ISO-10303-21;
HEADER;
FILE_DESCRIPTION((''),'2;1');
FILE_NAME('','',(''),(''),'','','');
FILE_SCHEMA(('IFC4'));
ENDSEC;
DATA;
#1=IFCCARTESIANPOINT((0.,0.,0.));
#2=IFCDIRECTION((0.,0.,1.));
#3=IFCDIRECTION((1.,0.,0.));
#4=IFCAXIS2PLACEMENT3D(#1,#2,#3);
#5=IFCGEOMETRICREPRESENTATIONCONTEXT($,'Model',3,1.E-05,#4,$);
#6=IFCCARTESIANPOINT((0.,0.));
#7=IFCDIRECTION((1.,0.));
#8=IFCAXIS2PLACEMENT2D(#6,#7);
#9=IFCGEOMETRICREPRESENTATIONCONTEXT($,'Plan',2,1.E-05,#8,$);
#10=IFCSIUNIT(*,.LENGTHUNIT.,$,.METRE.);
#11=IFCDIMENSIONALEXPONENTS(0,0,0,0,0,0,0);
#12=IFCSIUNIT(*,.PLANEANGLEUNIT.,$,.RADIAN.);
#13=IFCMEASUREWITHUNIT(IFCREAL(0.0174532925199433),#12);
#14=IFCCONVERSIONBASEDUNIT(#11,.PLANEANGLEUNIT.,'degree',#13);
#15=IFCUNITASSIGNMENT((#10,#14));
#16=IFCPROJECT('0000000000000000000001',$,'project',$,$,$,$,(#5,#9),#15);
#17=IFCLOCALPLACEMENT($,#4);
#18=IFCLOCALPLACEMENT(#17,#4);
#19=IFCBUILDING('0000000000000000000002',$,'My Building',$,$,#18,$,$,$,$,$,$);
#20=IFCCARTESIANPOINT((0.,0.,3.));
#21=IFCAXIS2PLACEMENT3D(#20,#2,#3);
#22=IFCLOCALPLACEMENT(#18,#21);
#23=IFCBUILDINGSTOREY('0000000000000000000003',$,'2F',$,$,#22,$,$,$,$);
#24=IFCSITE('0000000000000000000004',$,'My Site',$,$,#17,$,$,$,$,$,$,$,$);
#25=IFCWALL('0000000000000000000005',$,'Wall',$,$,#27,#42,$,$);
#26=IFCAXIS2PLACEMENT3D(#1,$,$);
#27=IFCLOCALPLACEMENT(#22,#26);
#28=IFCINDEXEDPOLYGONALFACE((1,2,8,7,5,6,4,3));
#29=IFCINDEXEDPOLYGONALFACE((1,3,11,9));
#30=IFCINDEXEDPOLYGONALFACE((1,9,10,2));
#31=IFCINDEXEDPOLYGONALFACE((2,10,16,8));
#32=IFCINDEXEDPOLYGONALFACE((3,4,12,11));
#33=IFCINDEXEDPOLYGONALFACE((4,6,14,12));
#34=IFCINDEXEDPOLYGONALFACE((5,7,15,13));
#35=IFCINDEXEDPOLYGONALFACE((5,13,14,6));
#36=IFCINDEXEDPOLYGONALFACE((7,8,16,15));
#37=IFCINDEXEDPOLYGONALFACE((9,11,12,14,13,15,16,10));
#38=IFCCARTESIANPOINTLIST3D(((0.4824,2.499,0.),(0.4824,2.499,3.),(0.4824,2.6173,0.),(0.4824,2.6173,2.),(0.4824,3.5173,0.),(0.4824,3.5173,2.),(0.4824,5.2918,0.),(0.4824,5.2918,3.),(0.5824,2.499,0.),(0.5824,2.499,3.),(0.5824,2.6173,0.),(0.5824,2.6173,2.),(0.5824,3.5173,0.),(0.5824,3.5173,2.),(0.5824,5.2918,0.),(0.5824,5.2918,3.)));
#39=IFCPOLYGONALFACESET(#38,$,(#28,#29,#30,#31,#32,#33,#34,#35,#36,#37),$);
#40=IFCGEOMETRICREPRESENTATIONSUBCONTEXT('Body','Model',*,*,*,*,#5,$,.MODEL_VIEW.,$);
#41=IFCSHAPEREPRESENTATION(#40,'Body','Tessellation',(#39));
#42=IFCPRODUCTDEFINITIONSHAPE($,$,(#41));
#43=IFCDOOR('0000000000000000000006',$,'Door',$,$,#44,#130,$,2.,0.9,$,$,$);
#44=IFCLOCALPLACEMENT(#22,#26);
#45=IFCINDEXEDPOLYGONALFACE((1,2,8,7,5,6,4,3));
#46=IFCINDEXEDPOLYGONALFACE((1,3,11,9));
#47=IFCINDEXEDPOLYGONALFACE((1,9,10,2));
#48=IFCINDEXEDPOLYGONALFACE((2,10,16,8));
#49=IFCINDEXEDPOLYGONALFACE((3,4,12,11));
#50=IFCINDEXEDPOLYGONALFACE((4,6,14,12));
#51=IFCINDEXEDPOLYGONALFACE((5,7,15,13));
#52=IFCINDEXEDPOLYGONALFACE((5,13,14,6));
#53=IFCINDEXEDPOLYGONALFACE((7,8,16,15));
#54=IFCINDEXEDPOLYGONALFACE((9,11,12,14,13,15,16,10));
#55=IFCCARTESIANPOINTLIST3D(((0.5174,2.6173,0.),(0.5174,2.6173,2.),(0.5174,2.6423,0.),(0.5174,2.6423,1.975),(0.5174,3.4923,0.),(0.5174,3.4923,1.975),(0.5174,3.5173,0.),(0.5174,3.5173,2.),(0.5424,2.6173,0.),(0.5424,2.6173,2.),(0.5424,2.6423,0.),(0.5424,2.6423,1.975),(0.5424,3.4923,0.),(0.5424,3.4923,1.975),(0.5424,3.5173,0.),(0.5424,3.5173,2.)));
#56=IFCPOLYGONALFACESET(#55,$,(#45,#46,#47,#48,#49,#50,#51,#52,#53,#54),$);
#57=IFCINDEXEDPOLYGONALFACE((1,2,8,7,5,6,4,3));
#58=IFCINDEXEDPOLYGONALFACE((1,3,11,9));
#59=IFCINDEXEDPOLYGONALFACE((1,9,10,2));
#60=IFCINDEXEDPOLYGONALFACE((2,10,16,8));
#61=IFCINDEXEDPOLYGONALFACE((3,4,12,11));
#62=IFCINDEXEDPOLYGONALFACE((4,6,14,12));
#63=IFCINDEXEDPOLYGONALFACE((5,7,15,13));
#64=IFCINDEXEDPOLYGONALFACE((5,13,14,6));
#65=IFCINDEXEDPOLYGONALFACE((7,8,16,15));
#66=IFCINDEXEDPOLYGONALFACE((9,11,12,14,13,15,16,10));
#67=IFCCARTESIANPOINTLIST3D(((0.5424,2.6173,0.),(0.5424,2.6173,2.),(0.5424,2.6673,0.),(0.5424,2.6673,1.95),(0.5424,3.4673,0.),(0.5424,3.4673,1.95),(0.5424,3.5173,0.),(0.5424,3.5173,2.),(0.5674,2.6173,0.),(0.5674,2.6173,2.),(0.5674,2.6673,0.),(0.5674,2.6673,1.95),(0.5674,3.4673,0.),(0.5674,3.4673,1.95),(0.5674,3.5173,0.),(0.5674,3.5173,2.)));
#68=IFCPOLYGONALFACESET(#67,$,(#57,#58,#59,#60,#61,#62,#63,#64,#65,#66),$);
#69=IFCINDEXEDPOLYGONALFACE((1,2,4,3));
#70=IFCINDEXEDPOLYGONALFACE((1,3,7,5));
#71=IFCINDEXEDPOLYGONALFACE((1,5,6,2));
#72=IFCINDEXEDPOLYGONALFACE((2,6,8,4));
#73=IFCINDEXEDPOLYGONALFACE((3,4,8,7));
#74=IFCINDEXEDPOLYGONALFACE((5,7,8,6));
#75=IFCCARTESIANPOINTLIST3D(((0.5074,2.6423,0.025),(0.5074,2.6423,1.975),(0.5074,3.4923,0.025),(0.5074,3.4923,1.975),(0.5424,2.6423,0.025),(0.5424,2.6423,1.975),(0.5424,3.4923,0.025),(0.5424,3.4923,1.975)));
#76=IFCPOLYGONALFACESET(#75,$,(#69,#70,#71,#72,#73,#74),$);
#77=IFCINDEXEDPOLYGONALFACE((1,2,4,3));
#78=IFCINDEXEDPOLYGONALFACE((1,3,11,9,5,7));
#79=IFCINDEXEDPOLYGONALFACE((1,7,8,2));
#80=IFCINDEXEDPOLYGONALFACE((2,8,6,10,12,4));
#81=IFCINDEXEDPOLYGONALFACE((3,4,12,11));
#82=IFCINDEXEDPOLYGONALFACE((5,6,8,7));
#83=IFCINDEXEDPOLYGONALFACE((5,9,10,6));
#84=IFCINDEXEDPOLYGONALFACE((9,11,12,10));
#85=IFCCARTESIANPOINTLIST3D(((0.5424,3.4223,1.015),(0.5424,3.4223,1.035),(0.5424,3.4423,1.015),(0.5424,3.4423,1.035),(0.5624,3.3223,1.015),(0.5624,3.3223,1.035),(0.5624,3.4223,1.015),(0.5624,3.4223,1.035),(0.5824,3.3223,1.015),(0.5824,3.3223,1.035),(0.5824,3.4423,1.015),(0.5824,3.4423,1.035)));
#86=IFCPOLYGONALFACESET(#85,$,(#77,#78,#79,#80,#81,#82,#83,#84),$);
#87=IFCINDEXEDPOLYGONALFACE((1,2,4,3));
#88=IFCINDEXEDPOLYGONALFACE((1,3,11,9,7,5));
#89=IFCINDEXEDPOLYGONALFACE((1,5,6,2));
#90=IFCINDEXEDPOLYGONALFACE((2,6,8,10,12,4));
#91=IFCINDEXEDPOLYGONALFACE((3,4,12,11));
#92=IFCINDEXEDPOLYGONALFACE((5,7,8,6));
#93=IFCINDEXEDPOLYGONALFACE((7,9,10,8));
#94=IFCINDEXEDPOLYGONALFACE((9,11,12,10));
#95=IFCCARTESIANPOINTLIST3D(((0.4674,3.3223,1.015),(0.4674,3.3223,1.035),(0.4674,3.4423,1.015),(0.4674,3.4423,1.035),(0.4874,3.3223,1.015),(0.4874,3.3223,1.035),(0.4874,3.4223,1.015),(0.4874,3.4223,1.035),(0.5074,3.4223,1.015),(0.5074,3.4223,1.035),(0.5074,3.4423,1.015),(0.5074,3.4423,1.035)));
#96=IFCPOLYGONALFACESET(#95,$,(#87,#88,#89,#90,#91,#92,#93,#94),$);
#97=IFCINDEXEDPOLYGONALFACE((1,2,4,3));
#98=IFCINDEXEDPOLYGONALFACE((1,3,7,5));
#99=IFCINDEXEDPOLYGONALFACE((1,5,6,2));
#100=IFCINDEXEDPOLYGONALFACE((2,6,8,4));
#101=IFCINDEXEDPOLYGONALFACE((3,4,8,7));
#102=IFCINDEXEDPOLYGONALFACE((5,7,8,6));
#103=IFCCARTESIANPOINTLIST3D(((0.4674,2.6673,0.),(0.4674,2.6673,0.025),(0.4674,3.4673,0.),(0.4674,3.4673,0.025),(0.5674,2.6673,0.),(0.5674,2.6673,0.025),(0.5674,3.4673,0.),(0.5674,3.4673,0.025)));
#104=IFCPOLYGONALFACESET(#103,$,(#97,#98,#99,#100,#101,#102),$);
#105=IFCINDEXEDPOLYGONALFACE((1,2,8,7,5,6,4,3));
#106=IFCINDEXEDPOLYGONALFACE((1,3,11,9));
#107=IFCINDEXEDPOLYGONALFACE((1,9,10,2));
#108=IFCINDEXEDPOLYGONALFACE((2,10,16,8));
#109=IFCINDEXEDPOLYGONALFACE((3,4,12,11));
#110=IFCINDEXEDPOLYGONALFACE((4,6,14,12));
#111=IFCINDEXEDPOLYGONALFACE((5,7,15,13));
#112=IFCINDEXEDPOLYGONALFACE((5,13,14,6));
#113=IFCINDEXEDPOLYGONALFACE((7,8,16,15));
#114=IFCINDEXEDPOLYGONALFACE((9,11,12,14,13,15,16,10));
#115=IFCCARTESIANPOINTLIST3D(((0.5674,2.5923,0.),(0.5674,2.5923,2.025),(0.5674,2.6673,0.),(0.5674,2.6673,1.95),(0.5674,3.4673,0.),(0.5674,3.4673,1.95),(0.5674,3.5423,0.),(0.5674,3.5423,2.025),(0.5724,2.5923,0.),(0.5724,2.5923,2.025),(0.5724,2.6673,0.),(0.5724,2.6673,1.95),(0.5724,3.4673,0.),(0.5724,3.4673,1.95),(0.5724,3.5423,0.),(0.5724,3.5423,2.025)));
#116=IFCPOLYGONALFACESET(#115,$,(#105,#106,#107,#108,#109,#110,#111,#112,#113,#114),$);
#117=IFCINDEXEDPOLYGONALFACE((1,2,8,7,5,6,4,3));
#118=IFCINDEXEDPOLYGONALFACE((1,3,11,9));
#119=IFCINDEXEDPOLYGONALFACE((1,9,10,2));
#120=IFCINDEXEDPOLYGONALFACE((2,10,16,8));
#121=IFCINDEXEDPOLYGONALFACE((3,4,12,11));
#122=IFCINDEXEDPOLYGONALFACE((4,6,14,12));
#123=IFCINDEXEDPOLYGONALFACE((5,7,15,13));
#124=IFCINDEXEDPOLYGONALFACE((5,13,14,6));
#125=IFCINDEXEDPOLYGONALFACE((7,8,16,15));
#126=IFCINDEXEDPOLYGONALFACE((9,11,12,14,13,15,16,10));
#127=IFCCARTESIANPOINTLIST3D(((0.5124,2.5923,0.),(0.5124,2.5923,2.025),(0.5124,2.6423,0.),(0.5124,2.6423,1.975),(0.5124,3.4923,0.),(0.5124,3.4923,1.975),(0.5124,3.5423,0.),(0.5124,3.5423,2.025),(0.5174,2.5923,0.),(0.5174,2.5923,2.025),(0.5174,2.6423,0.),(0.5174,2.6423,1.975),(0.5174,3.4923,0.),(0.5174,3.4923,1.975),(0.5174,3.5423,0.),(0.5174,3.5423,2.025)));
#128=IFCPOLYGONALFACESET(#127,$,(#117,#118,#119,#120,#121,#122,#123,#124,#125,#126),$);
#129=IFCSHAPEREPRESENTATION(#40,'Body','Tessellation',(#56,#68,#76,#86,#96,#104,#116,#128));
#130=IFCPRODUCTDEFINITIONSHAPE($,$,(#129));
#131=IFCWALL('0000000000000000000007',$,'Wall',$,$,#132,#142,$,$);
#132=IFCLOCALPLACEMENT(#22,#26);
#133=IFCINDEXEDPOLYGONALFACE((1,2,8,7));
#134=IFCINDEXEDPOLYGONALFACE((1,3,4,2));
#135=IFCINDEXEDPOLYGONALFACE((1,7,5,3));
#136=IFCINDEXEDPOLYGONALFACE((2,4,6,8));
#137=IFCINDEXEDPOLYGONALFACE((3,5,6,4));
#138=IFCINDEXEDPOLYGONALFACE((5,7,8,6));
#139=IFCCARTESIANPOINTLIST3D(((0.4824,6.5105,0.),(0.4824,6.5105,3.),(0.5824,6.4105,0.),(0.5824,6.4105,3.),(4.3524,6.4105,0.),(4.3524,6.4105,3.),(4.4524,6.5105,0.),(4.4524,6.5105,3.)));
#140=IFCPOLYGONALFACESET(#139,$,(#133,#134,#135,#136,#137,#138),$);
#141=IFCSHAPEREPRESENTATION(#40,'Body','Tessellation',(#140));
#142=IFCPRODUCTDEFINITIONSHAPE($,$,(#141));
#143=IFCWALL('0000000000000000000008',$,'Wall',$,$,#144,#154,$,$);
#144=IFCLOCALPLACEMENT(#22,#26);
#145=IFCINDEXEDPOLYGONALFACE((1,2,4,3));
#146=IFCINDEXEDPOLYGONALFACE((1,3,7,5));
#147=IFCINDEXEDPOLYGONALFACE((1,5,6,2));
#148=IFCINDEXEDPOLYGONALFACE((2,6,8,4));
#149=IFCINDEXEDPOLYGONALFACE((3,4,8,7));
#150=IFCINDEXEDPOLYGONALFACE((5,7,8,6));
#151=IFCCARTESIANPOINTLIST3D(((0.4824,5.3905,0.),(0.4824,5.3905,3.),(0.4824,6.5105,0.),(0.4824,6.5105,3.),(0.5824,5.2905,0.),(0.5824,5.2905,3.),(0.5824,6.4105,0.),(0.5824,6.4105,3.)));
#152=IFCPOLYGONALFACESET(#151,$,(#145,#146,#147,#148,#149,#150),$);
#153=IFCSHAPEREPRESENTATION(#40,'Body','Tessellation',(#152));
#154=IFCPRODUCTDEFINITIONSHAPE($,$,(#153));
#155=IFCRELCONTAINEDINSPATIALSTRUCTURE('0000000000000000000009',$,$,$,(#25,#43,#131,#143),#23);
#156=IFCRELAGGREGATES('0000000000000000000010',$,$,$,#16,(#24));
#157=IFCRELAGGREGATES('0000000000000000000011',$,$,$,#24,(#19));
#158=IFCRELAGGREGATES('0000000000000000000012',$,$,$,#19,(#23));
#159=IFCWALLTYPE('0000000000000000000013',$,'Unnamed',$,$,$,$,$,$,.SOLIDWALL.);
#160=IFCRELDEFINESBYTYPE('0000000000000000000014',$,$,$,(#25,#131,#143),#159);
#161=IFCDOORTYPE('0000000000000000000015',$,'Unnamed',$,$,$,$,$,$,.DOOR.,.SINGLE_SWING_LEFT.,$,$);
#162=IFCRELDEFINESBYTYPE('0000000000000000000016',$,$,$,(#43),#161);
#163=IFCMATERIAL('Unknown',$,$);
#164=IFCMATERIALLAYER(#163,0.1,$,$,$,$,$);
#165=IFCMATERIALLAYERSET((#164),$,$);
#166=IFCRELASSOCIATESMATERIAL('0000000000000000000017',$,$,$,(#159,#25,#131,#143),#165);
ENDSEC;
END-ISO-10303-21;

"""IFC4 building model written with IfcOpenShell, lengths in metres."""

from ifc_helpers import new_model, entity, si_unit, converted_unit, frame, origin_with_axes, origin_2d_with_axis, place, context, subcontext, project, spatial, line, indexed_curve, outline, extrude, shape, source, transform, mapped, material, layer, layer_set, layer_usage, type_object, type_shapes, element, fill, save


model = new_model("IFC4")

# Units and contexts
model_context = context("Model", 3, precision=1e-05, world=origin_with_axes())
plan_context = context("Plan", 2, precision=1e-05, world=origin_2d_with_axis())
body_context_1 = subcontext(model_context, "Body", "Model", "MODEL_VIEW")
body_context_2 = subcontext(plan_context, "Body", "Plan", "PLAN_VIEW")
ifc_project = project(units=[si_unit("LENGTHUNIT", "METRE"), converted_unit("PLANEANGLEUNIT", "degree", entity("IfcReal", 0.0174532925199433), si_unit("PLANEANGLEUNIT", "RADIAN"), dimensions=[0, 0, 0, 0, 0, 0, 0])], contexts=[model_context, plan_context])

# Site, building, storey
site_placement = place(None, origin_with_axes())
site = spatial("IfcSite", under=ifc_project, at=site_placement, Name="My Site")
building_placement = place(site_placement, origin_with_axes())
building = spatial("IfcBuilding", under=site, at=building_placement, Name="My Building")
storey_placement = place(building_placement, frame((0.0, 0.0, 3.0), z_axis=(0.0, 0.0, 1.0), x_axis=(1.0, 0.0, 0.0)))
storey = spatial("IfcBuildingStorey", under=building, at=storey_placement, Name="2F")

# Shared definitions
ifc_material = material(Name="Unknown")

# Shared definitions
ifc_layer = layer(ifc_material, 0.1)
ifc_layer_set = layer_set([ifc_layer])
wall_type = type_object("IfcWallType", Name="Unnamed", PredefinedType="SOLIDWALL", material=ifc_layer_set)

# Wall, opening, door
shared_shape_1 = source(origin_with_axes(), body_context_1, "Body", "SweptSolid", [
    extrude(outline(indexed_curve([(0.0, 0.0), (0.9, 0.0), (0.9, 2.0), (0.0, 2.0)], segments=[line(1, 2, 3, 4, 1)])), frame((0.0, -0.6, 0.0), z_axis=(0.0, -1.0, 0.0), x_axis=(1.0, 0.0, 0.0)), (0.0, 0.0, -1.0), 1.2),
])
door_type_1 = type_object("IfcDoorType", Name="Unnamed", OperationType="SINGLE_SWING_LEFT", PredefinedType="DOOR")
shared_shape_2 = source(origin_with_axes(), body_context_1, "Body", "SweptSolid", [
    extrude(outline(indexed_curve([(0.0, 0.0), (0.0, 2.0), (0.9, 2.0), (0.9, 0.0), (0.875, 0.0), (0.875, 1.975), (0.025, 1.975), (0.025, 0.0)], segments=[line(1, 2, 3, 4, 5, 6, 7, 8, 1)])), frame((0.0, 0.025, 0.0), z_axis=(0.0, -1.0, 0.0), x_axis=(1.0, 0.0, 0.0)), (0.0, 0.0, -1.0), 0.025),
    extrude(outline(indexed_curve([(0.0, 0.0), (0.0, 2.0), (0.9, 2.0), (0.9, 0.0), (0.85, 0.0), (0.85, 1.95), (0.05, 1.95), (0.05, 0.0)], segments=[line(1, 2, 3, 4, 5, 6, 7, 8, 1)])), frame((0.0, 0.0, 0.0), z_axis=(0.0, -1.0, 0.0), x_axis=(1.0, 0.0, 0.0)), (0.0, 0.0, -1.0), 0.025),
    extrude(outline(indexed_curve([(0.0, 0.0), (0.85, 0.0), (0.85, 0.035), (0.0, 0.035)], segments=[line(1, 2, 3, 4, 1)])), frame((0.025, 0.025, 0.025), z_axis=(0.0, 0.0, 1.0), x_axis=(1.0, 0.0, 0.0)), (0.0, 0.0, 1.0), 1.95),
    extrude(outline(indexed_curve([(0.0, 0.0), (0.0, -0.04), (-0.12, -0.04), (-0.12, -0.02), (-0.02, -0.02), (-0.02, 0.0)], segments=[line(1, 2, 3, 4, 5, 6, 1)])), frame((0.825, 0.025, 1.015), z_axis=(0.0, 0.0, 1.0), x_axis=(1.0, 0.0, 0.0)), (0.0, 0.0, 1.0), 0.02),
    extrude(outline(indexed_curve([(0.0, 0.0), (0.0, 0.04), (-0.12, 0.04), (-0.12, 0.02), (-0.02, 0.02), (-0.02, 0.0)], segments=[line(1, 2, 3, 4, 5, 6, 1)])), frame((0.825, 0.06, 1.015), z_axis=(0.0, 0.0, 1.0), x_axis=(1.0, 0.0, 0.0)), (0.0, 0.0, 1.0), 0.02),
    extrude(outline(indexed_curve([(0.0, 0.0), (0.8, 0.0), (0.8, 0.1), (0.0, 0.1)], segments=[line(1, 2, 3, 4, 1)])), frame((0.05, 0.0, 0.0), z_axis=(0.0, 0.0, 1.0), x_axis=(1.0, 0.0, 0.0)), (0.0, 0.0, 1.0), 0.025),
    extrude(outline(indexed_curve([(0.0, 0.0), (0.0, 2.025), (0.95, 2.025), (0.95, 0.0), (0.875, 0.0), (0.875, 1.95), (0.075, 1.95), (0.075, 0.0)], segments=[line(1, 2, 3, 4, 5, 6, 7, 8, 1)])), frame((-0.025, -0.005, 0.0), z_axis=(0.0, -1.0, 0.0), x_axis=(1.0, 0.0, 0.0)), (0.0, 0.0, -1.0), 0.005),
    extrude(outline(indexed_curve([(0.0, 0.0), (0.0, 2.025), (0.95, 2.025), (0.95, 0.0), (0.9, 0.0), (0.9, 1.975), (0.05, 1.975), (0.05, 0.0)], segments=[line(1, 2, 3, 4, 5, 6, 7, 8, 1)])), frame((-0.025, 0.05, 0.0), z_axis=(0.0, -1.0, 0.0), x_axis=(1.0, 0.0, 0.0)), (0.0, 0.0, -1.0), 0.005),
])
shared_shape_3 = source(origin_with_axes(), body_context_2, "Body", "Curve2D", [
    entity("IfcIndexedPolyCurve", entity("IfcCartesianPointList2D", [[0.0, 0.0], [0.0, 0.05], [0.025, 0.05], [0.025, 0.025], [0.05, 0.025], [0.05, 0.0]]), [entity("IfcLineIndex", [1, 2, 3, 4, 5, 6, 1])]),
    entity("IfcIndexedPolyCurve", entity("IfcCartesianPointList2D", [[0.9, 0.0], [0.9, 0.05], [0.875, 0.05], [0.875, 0.025], [0.85, 0.025], [0.85, 0.0]]), [entity("IfcLineIndex", [1, 2, 3, 4, 5, 6, 1])]),
    entity("IfcTrimmedCurve", entity("IfcEllipse", entity("IfcAxis2Placement2D", entity("IfcCartesianPoint", [0.06, 0.05]), entity("IfcDirection", [1.0, 0.0])), 0.815, 0.85), [entity("IfcCartesianPoint", [0.875, 0.05])], [entity("IfcCartesianPoint", [0.06, 0.9])], True, "CARTESIAN"),
    entity("IfcIndexedPolyCurve", entity("IfcCartesianPointList2D", [[0.025, 0.05], [0.06, 0.05], [0.06, 0.9], [0.025, 0.9]]), [entity("IfcLineIndex", [1, 2, 3, 4, 1])]),
])
type_shapes(door_type_1, [shared_shape_2, shared_shape_3])
ifc_layer_usage_1 = layer_usage(ifc_layer_set, "AXIS2", "POSITIVE", 0.0)
wall_1_placement = place(storey_placement, frame((0.4824, 5.2918, 0.0), z_axis=(0.0, 0.0, 1.0), x_axis=(0.0, -1.0, 0.0)))
wall_1 = element("IfcWall", 1, at=wall_1_placement, inside=storey, type_object=wall_type, material=ifc_layer_usage_1, Name="Wall", context=body_context_1, shape_type="SweptSolid", body=[
    extrude(outline(indexed_curve([(0.0, 0.0), (0.0, 0.1), (2.7929, 0.1), (2.7929, 0.0)], segments=[line(1, 2, 3, 4, 1)])), origin_with_axes(), (0.0, 0.0, 1.0), 3.0),
])
opening_1_placement = place(wall_1_placement, frame((1.7746, 0.0, 0.0), z_axis=(0.0, 0.0, 1.0), x_axis=(1.0, 0.0, 0.0)))
opening_1 = element("IfcOpeningElement", 2, at=opening_1_placement, cuts=wall_1, PredefinedType="OPENING", context=body_context_1, shape_type="MappedRepresentation", body=[
    mapped(shared_shape_1, transform((0.0, 0.0, 0.0), x_axis=(1.0, 0.0, 0.0), y_axis=(0.0, 1.0, 0.0), z_axis=(0.0, 0.0, 1.0), scale=1.0)),
])
door_1_placement = place(opening_1_placement, frame((0.9, 0.085, 0.0), z_axis=(0.0, 0.0, 1.0), x_axis=(-1.0, 0.0, 0.0)))
door_1 = element("IfcDoor", 3, at=door_1_placement, inside=storey, type_object=door_type_1, Name="Door", OverallHeight=2.0, OverallWidth=0.9, shapes=[
    shape(body_context_1, "Body", "MappedRepresentation", [mapped(shared_shape_2, transform((0.0, 0.0, 0.0), x_axis=(1.0, 0.0, 0.0), y_axis=(0.0, 1.0, 0.0), z_axis=(0.0, 0.0, 1.0), scale=1.0))]),
    shape(body_context_2, "Body", "MappedRepresentation", [mapped(shared_shape_3, transform((0.0, 0.0, 0.0), x_axis=(1.0, 0.0, 0.0), y_axis=(0.0, 1.0, 0.0), z_axis=(0.0, 0.0, 1.0), scale=1.0))]),
])
fill(opening_1, door_1)

# Walls
ifc_layer_usage_2 = layer_usage(ifc_layer_set, "AXIS2", "POSITIVE", 0.0)
wall_2_placement = place(storey_placement, frame((4.4524, 6.5105, 0.0), z_axis=(0.0, 0.0, 1.0), x_axis=(-1.0, 0.0, 0.0)))
element("IfcWall", 4, at=wall_2_placement, inside=storey, type_object=wall_type, material=ifc_layer_usage_2, Name="Wall", context=body_context_1, shape_type="SweptSolid", body=[
    extrude(outline(indexed_curve([(0.0, 0.0), (0.1, 0.1), (3.87, 0.1), (3.97, 0.0)], segments=[line(1, 2, 3, 4, 1)])), origin_with_axes(), (0.0, 0.0, 1.0), 3.0),
])
ifc_layer_usage_3 = layer_usage(ifc_layer_set, "AXIS2", "POSITIVE", 0.0)
wall_3_placement = place(storey_placement, frame((0.4824, 6.5105, 0.0), z_axis=(0.0, 0.0, 1.0), x_axis=(0.0, -1.0, 0.0)))
element("IfcWall", 5, at=wall_3_placement, inside=storey, type_object=wall_type, material=ifc_layer_usage_3, Name="Wall", context=body_context_1, shape_type="SweptSolid", body=[
    extrude(outline(indexed_curve([(0.0, 0.0), (0.1, 0.1), (1.22, 0.1), (1.12, 0.0)], segments=[line(1, 2, 3, 4, 1)])), origin_with_axes(), (0.0, 0.0, 1.0), 3.0),
])

save(model, "model.ifc")
